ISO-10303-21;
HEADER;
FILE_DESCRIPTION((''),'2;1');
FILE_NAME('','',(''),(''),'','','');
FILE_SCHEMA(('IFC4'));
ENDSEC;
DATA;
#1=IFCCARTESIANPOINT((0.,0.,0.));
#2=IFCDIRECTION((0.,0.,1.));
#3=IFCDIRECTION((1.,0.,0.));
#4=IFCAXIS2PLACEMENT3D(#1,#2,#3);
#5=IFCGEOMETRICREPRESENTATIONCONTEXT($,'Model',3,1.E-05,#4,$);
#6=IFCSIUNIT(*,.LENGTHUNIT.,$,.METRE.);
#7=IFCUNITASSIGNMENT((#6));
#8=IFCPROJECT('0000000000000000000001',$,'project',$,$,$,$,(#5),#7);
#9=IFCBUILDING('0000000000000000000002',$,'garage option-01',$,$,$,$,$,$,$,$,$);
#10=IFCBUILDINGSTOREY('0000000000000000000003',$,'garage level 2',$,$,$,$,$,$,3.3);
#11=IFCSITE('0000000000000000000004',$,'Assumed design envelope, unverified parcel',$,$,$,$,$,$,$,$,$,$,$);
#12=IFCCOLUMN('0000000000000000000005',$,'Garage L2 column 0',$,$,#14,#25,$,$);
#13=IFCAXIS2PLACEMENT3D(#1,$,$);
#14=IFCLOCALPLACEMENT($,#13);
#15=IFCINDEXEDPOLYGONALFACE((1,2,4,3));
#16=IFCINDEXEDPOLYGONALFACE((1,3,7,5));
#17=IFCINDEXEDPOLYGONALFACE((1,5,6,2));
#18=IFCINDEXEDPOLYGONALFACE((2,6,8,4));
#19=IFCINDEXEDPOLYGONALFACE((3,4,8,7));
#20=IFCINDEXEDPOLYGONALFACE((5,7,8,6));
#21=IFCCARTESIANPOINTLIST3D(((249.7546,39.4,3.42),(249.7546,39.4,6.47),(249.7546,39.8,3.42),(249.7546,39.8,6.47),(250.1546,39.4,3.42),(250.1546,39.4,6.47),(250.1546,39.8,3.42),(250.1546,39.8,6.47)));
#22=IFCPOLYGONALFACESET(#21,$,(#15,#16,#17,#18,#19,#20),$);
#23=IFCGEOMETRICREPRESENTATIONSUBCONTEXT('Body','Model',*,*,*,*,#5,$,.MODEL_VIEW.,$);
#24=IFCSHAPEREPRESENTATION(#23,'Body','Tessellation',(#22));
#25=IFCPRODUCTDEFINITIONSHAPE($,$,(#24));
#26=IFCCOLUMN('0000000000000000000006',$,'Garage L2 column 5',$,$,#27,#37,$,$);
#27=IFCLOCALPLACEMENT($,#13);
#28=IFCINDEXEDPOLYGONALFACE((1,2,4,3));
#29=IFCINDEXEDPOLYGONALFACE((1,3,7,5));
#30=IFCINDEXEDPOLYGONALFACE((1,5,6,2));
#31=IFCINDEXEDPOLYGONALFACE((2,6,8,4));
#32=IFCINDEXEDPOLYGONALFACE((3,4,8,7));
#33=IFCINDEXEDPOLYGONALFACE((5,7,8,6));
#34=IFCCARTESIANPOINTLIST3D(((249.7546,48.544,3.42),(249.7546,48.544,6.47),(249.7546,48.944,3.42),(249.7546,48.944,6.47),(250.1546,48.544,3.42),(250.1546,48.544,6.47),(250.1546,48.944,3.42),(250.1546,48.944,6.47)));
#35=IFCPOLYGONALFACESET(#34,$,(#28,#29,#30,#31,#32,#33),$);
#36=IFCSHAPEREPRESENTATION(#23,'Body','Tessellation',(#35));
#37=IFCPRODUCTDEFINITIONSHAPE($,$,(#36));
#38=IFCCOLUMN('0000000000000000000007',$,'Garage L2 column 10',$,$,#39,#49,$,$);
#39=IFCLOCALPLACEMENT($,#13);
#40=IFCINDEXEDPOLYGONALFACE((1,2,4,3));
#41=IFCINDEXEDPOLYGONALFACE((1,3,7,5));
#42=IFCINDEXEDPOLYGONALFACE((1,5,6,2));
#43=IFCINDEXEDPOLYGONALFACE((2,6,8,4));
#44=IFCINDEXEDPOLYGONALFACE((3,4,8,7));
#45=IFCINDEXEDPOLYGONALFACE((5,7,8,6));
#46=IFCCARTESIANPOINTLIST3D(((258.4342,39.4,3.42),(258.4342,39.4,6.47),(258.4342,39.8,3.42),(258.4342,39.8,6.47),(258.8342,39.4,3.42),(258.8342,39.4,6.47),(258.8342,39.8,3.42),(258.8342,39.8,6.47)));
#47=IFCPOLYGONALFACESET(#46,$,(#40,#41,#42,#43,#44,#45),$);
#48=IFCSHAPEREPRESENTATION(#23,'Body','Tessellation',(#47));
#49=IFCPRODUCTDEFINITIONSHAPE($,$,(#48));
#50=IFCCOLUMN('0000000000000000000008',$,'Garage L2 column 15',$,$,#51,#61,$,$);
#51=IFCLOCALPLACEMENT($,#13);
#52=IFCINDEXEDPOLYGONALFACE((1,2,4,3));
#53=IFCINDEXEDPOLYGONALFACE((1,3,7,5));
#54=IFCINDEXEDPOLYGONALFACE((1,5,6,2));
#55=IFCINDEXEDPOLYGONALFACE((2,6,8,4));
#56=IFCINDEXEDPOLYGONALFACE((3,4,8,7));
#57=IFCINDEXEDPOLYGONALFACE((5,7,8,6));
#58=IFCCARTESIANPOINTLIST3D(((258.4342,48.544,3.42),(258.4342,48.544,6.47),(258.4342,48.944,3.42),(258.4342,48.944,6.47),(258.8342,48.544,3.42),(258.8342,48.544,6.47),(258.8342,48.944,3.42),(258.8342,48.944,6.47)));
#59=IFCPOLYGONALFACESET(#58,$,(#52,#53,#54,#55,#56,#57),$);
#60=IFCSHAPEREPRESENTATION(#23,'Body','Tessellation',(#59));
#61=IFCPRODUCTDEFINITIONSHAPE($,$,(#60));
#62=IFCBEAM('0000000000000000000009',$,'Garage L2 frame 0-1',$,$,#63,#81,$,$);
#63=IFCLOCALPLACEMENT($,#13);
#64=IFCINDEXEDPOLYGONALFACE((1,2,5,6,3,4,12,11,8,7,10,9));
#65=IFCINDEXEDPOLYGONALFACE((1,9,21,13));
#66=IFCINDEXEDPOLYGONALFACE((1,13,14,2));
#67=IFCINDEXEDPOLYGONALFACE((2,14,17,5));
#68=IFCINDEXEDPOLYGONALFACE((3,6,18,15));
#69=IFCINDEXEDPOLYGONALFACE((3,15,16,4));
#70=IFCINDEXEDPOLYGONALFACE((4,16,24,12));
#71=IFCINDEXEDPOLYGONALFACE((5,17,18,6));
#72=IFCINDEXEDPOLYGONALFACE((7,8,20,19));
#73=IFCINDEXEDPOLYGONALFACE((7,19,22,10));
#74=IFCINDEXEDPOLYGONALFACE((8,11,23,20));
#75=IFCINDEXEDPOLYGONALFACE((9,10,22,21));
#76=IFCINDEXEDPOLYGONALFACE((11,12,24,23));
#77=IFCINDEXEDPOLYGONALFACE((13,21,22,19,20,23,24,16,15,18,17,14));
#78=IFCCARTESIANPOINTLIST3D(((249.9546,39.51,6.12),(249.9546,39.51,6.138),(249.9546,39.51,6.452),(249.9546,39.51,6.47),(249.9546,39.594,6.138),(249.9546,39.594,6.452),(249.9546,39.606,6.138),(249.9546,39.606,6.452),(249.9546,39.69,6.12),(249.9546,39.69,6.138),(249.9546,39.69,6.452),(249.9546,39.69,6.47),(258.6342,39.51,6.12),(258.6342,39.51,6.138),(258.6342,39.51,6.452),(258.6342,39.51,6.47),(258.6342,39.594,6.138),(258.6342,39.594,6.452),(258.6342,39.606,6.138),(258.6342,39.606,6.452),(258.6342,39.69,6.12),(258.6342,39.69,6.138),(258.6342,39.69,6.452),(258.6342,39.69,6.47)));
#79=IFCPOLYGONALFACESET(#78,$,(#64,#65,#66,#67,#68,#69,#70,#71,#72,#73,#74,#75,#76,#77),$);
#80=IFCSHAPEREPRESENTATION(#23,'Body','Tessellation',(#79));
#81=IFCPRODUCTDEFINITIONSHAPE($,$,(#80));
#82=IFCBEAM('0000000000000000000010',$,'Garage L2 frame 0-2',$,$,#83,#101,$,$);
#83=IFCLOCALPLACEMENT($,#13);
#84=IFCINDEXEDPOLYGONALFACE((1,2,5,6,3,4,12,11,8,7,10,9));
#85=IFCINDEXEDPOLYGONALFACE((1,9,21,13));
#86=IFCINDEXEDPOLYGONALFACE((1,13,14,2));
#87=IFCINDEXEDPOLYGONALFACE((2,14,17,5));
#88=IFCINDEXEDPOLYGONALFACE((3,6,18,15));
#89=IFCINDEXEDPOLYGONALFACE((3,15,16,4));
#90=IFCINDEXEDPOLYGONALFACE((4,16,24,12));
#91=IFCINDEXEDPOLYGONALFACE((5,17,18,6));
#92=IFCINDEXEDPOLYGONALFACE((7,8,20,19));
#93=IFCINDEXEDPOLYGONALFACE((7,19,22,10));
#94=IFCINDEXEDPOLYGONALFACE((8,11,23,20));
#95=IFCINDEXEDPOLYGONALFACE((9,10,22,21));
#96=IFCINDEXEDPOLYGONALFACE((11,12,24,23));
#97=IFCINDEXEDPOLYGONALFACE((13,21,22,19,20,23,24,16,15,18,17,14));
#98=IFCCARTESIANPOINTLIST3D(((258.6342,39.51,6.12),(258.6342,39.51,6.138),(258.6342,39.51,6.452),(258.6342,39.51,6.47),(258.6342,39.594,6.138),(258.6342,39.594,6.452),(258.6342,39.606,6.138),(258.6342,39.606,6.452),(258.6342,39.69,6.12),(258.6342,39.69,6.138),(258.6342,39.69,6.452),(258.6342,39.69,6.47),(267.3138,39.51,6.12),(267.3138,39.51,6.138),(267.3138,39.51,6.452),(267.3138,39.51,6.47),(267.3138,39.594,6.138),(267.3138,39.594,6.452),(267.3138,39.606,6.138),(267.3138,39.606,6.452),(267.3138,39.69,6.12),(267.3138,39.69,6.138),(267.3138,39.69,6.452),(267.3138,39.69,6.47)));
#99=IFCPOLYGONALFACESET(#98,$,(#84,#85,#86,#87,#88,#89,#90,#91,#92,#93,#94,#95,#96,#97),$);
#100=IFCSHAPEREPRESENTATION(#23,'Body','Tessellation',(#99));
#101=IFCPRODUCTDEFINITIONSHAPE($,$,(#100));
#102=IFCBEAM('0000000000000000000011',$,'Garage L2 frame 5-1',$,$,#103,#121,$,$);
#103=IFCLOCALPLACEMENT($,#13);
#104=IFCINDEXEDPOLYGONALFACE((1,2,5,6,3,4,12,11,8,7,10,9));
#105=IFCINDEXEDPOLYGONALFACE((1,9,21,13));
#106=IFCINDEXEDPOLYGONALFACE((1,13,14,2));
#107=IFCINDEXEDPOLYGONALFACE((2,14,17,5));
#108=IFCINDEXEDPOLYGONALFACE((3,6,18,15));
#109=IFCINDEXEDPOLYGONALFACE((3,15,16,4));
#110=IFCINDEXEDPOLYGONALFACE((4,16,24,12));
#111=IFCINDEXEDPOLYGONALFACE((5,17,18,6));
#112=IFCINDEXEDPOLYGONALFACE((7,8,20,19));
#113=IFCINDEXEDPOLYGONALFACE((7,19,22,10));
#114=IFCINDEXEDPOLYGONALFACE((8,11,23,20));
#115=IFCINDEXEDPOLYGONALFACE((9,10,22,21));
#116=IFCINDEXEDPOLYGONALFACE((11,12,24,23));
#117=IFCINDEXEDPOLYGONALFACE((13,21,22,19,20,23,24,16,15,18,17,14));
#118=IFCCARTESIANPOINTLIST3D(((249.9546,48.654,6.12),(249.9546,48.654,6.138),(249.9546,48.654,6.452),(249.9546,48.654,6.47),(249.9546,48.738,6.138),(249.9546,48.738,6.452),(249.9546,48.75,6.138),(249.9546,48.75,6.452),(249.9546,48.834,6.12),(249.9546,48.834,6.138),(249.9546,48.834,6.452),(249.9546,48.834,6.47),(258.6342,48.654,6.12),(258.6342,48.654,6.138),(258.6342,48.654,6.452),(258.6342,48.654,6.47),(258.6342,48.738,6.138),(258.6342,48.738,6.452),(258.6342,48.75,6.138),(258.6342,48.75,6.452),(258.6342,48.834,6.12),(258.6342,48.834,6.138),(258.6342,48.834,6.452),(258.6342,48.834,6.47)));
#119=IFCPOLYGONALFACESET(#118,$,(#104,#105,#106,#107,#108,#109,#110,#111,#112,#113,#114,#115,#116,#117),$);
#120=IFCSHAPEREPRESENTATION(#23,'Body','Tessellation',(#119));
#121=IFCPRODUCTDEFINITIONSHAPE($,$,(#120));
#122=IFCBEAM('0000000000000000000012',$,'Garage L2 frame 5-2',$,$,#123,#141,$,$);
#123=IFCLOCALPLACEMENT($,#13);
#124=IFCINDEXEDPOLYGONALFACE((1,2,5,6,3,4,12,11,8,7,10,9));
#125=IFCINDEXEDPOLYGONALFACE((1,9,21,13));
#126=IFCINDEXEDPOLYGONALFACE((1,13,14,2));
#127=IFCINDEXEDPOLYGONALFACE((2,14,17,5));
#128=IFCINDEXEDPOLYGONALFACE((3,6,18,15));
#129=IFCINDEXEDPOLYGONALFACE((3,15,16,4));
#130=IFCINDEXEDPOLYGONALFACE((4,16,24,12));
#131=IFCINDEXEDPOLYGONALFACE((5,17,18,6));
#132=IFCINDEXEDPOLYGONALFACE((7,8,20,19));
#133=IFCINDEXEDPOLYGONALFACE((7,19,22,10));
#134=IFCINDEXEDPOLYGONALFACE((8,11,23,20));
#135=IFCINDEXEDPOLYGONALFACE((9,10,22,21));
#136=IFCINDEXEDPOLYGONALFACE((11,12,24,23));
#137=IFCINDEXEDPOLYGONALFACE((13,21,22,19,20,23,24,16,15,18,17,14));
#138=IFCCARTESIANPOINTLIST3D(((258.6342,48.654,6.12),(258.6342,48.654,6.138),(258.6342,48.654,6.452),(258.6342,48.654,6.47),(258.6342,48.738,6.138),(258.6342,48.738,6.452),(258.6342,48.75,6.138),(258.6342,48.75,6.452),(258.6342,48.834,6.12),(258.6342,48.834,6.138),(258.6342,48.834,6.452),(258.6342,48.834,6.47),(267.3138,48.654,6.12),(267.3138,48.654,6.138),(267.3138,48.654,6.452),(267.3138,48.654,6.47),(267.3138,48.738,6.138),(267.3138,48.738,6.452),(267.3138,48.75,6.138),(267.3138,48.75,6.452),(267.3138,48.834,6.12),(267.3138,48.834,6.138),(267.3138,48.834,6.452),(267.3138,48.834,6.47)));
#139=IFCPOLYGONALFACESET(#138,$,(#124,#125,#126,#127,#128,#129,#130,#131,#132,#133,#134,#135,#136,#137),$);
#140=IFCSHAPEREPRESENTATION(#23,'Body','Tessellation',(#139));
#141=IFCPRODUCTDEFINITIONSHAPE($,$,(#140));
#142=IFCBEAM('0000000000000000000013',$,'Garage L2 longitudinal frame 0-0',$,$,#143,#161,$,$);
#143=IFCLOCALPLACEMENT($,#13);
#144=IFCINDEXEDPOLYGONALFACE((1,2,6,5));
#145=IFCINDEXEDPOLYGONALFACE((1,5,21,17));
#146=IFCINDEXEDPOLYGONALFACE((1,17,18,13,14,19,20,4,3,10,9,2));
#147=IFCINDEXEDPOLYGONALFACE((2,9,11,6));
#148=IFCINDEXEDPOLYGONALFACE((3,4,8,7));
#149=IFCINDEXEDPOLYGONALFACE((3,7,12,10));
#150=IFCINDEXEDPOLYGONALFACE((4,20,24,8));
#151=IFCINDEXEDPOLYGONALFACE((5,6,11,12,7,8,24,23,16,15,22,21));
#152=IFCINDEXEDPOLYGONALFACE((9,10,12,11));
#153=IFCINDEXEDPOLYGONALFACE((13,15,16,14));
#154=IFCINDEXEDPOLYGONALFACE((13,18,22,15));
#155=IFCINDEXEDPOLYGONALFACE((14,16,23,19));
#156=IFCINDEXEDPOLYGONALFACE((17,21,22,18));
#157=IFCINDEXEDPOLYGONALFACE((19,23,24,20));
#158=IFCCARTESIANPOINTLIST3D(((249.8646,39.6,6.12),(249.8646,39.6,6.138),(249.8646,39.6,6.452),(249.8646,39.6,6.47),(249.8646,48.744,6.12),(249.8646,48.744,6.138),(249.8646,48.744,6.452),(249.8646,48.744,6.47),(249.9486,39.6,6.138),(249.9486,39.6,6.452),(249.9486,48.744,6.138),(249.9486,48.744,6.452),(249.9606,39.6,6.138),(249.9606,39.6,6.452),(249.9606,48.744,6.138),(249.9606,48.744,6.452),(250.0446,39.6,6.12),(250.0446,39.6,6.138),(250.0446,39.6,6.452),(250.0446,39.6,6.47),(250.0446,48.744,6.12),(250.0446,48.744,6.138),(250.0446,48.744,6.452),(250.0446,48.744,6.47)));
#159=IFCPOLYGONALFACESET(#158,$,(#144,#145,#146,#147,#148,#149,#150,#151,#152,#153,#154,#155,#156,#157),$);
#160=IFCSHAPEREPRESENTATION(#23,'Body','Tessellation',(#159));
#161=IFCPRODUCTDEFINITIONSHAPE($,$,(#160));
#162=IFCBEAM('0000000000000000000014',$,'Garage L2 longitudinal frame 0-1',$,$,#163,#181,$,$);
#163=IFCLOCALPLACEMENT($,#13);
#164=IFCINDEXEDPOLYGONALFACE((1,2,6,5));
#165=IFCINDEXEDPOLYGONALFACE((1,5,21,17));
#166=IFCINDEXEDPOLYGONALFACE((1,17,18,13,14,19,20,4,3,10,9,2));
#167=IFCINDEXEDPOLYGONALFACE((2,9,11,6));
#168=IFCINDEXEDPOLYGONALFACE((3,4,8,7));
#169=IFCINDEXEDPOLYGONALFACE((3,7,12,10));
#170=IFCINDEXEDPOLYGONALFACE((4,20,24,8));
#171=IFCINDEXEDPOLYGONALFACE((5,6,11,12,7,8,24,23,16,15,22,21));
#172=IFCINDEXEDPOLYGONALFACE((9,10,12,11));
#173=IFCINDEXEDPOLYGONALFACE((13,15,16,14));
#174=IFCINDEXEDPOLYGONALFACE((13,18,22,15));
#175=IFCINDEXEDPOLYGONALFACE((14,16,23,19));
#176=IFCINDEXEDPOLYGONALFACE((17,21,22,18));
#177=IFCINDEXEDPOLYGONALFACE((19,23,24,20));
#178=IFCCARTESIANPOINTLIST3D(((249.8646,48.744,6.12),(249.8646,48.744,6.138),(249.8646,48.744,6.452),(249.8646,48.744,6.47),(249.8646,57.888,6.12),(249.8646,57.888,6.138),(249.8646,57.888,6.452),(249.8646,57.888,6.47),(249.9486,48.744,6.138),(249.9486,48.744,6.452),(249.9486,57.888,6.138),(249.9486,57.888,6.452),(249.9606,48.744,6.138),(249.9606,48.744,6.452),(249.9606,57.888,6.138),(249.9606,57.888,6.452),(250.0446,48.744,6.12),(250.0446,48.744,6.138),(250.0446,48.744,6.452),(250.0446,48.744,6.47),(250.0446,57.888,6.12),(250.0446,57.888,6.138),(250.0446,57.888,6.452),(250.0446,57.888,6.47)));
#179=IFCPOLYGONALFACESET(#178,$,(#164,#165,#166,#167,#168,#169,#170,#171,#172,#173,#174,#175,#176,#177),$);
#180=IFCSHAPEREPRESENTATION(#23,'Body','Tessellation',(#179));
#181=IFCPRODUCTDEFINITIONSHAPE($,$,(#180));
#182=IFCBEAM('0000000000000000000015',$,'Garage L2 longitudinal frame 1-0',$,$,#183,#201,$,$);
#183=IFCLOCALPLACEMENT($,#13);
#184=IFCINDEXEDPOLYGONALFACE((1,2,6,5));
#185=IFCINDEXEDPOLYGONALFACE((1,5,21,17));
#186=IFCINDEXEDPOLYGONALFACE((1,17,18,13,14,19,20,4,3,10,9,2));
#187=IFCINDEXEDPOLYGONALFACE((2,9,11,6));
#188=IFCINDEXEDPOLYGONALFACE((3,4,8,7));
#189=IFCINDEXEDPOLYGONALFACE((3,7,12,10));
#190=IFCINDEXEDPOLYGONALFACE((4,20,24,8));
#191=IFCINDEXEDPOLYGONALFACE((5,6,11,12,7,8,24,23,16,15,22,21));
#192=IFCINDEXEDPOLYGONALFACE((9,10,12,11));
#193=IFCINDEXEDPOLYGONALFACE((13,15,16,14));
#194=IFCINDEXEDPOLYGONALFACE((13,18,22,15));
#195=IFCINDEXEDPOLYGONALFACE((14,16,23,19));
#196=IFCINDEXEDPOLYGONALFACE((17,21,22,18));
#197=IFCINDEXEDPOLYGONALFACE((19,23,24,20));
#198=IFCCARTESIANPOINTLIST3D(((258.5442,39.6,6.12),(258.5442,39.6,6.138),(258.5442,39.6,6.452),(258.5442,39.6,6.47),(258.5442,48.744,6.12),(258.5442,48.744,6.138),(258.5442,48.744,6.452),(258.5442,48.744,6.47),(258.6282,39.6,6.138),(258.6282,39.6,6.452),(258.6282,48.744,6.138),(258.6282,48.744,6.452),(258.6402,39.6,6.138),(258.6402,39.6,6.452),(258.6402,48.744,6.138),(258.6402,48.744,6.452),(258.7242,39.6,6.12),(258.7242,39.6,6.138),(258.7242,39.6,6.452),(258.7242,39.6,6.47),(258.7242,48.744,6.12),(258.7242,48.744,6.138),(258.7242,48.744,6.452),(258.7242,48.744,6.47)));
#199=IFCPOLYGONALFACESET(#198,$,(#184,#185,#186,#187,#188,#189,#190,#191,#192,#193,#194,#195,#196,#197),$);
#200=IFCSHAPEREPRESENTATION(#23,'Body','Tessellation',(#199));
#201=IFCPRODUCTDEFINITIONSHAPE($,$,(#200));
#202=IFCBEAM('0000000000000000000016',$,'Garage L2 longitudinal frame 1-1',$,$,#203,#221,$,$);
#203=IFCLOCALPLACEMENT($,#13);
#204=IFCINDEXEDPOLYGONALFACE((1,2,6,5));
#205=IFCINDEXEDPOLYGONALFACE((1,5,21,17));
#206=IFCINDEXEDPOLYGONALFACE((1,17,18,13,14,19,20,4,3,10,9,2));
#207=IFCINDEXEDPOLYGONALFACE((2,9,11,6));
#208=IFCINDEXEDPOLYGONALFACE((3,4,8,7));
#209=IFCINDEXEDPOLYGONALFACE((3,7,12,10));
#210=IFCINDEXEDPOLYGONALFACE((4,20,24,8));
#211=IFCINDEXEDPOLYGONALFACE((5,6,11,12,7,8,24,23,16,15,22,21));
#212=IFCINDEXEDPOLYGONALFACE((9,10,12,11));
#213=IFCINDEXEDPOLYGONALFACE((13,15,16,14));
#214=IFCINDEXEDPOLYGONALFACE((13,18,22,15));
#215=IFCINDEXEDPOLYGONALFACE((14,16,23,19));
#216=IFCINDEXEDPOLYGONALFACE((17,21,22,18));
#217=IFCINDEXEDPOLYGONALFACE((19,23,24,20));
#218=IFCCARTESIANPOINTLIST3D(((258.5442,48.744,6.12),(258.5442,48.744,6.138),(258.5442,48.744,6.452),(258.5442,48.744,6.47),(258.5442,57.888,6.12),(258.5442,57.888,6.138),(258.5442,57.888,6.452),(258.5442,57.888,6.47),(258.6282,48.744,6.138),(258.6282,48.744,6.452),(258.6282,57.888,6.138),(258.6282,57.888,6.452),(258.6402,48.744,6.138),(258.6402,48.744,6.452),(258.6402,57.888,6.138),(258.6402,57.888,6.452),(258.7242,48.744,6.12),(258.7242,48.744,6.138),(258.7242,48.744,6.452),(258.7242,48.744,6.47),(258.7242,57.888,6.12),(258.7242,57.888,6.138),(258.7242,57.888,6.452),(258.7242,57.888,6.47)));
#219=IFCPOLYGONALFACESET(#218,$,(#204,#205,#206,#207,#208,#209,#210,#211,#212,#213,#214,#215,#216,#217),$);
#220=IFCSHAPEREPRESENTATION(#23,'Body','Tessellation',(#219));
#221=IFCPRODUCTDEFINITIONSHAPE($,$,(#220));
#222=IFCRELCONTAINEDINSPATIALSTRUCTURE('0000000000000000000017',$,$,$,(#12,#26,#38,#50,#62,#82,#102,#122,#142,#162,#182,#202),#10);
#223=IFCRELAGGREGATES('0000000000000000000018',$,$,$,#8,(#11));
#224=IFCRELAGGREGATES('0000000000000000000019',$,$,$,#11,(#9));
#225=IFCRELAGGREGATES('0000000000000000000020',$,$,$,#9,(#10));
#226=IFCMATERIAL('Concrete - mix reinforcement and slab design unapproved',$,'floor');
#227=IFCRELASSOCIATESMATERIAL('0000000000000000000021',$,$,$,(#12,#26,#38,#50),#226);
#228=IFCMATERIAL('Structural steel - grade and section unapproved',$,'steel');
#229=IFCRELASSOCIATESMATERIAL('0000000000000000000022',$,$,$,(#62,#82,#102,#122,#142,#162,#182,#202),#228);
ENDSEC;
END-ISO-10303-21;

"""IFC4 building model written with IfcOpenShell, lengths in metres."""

from ifc_helpers import new_model, si_unit, frame, origin_with_axes, place, context, subcontext, project, spatial, rectangle, i_section, extrude, material, element, save


model = new_model("IFC4")

# Units and contexts
model_context = context("Model", 3, precision=1e-05, world=origin_with_axes())
body_context = subcontext(model_context, "Body", "Model", "MODEL_VIEW")
ifc_project = project(units=[si_unit("LENGTHUNIT", "METRE")], contexts=[model_context])

# Site, building, storey
site = spatial("IfcSite", under=ifc_project, Name="Assumed design envelope, unverified parcel")
building = spatial("IfcBuilding", under=site, Name="garage option-01")
storey = spatial("IfcBuildingStorey", under=building, Name="garage level 2", Elevation=3.3)

# Columns
ifc_material_1 = material(Name="Concrete - mix reinforcement and slab design unapproved", Category="floor")
for number, where, z_axis, x_axis, name in (
    (1, (249.9546, 39.6, 3.42), (0.0, 0.0, 1.0), (1.0, 0.0, 0.0), "Garage L2 column 0"),
    (2, (249.9546, 48.744, 3.42), (0.0, 0.0, 1.0), (1.0, 0.0, 0.0), "Garage L2 column 5"),
    (3, (258.6342, 39.6, 3.42), (0.0, 0.0, 1.0), (1.0, 0.0, 0.0), "Garage L2 column 10"),
    (4, (258.6342, 48.744, 3.42), (0.0, 0.0, 1.0), (1.0, 0.0, 0.0), "Garage L2 column 15"),
):
    element("IfcColumn", number, at=place(None, frame(where, z_axis=z_axis, x_axis=x_axis)), inside=storey, material=ifc_material_1, Name=name, context=body_context, shape_type="SweptSolid", body=[
        extrude(rectangle(XDim=0.4, YDim=0.4), origin_with_axes(), (0.0, 0.0, 1.0), 3.05),
    ])

# Beams
ifc_material_2 = material(Name="Structural steel - grade and section unapproved", Category="steel")
beam_1_placement = place(None, frame((249.9546, 39.6, 6.295), z_axis=(1.0, 0.0, 0.0), x_axis=(0.0, 1.0, 0.0)))
element("IfcBeam", 5, at=beam_1_placement, inside=storey, material=ifc_material_2, Name="Garage L2 frame 0-1", context=body_context, shape_type="SweptSolid", body=[
    extrude(i_section(OverallWidth=0.18, OverallDepth=0.35, WebThickness=0.012, FlangeThickness=0.018, FilletRadius=0.0), origin_with_axes(), (0.0, 0.0, 1.0), 8.6796),
])
beam_2_placement = place(None, frame((258.6342, 39.6, 6.295), z_axis=(1.0, 0.0, 0.0), x_axis=(0.0, 1.0, 0.0)))
element("IfcBeam", 6, at=beam_2_placement, inside=storey, material=ifc_material_2, Name="Garage L2 frame 0-2", context=body_context, shape_type="SweptSolid", body=[
    extrude(i_section(OverallWidth=0.18, OverallDepth=0.35, WebThickness=0.012, FlangeThickness=0.018, FilletRadius=0.0), origin_with_axes(), (0.0, 0.0, 1.0), 8.6796),
])
beam_3_placement = place(None, frame((249.9546, 48.744, 6.295), z_axis=(1.0, 0.0, 0.0), x_axis=(0.0, 1.0, 0.0)))
element("IfcBeam", 7, at=beam_3_placement, inside=storey, material=ifc_material_2, Name="Garage L2 frame 5-1", context=body_context, shape_type="SweptSolid", body=[
    extrude(i_section(OverallWidth=0.18, OverallDepth=0.35, WebThickness=0.012, FlangeThickness=0.018, FilletRadius=0.0), origin_with_axes(), (0.0, 0.0, 1.0), 8.6796),
])
beam_4_placement = place(None, frame((258.6342, 48.744, 6.295), z_axis=(1.0, 0.0, 0.0), x_axis=(0.0, 1.0, 0.0)))
element("IfcBeam", 8, at=beam_4_placement, inside=storey, material=ifc_material_2, Name="Garage L2 frame 5-2", context=body_context, shape_type="SweptSolid", body=[
    extrude(i_section(OverallWidth=0.18, OverallDepth=0.35, WebThickness=0.012, FlangeThickness=0.018, FilletRadius=0.0), origin_with_axes(), (0.0, 0.0, 1.0), 8.6796),
])
for number, where, z_axis, x_axis, name in (
    (9, (249.9546, 39.6, 6.295), (0.0, 1.0, 0.0), (-1.0, 0.0, 0.0), "Garage L2 longitudinal frame 0-0"),
    (10, (249.9546, 48.744, 6.295), (0.0, 1.0, 0.0), (-1.0, 0.0, 0.0), "Garage L2 longitudinal frame 0-1"),
    (11, (258.6342, 39.6, 6.295), (0.0, 1.0, 0.0), (-1.0, 0.0, 0.0), "Garage L2 longitudinal frame 1-0"),
    (12, (258.6342, 48.744, 6.295), (0.0, 1.0, 0.0), (-1.0, 0.0, 0.0), "Garage L2 longitudinal frame 1-1"),
):
    element("IfcBeam", number, at=place(None, frame(where, z_axis=z_axis, x_axis=x_axis)), inside=storey, material=ifc_material_2, Name=name, context=body_context, shape_type="SweptSolid", body=[
        extrude(i_section(OverallWidth=0.18, OverallDepth=0.35, WebThickness=0.012, FlangeThickness=0.018, FilletRadius=0.0), origin_with_axes(), (0.0, 0.0, 1.0), 9.144),
    ])

save(model, "model.ifc")
